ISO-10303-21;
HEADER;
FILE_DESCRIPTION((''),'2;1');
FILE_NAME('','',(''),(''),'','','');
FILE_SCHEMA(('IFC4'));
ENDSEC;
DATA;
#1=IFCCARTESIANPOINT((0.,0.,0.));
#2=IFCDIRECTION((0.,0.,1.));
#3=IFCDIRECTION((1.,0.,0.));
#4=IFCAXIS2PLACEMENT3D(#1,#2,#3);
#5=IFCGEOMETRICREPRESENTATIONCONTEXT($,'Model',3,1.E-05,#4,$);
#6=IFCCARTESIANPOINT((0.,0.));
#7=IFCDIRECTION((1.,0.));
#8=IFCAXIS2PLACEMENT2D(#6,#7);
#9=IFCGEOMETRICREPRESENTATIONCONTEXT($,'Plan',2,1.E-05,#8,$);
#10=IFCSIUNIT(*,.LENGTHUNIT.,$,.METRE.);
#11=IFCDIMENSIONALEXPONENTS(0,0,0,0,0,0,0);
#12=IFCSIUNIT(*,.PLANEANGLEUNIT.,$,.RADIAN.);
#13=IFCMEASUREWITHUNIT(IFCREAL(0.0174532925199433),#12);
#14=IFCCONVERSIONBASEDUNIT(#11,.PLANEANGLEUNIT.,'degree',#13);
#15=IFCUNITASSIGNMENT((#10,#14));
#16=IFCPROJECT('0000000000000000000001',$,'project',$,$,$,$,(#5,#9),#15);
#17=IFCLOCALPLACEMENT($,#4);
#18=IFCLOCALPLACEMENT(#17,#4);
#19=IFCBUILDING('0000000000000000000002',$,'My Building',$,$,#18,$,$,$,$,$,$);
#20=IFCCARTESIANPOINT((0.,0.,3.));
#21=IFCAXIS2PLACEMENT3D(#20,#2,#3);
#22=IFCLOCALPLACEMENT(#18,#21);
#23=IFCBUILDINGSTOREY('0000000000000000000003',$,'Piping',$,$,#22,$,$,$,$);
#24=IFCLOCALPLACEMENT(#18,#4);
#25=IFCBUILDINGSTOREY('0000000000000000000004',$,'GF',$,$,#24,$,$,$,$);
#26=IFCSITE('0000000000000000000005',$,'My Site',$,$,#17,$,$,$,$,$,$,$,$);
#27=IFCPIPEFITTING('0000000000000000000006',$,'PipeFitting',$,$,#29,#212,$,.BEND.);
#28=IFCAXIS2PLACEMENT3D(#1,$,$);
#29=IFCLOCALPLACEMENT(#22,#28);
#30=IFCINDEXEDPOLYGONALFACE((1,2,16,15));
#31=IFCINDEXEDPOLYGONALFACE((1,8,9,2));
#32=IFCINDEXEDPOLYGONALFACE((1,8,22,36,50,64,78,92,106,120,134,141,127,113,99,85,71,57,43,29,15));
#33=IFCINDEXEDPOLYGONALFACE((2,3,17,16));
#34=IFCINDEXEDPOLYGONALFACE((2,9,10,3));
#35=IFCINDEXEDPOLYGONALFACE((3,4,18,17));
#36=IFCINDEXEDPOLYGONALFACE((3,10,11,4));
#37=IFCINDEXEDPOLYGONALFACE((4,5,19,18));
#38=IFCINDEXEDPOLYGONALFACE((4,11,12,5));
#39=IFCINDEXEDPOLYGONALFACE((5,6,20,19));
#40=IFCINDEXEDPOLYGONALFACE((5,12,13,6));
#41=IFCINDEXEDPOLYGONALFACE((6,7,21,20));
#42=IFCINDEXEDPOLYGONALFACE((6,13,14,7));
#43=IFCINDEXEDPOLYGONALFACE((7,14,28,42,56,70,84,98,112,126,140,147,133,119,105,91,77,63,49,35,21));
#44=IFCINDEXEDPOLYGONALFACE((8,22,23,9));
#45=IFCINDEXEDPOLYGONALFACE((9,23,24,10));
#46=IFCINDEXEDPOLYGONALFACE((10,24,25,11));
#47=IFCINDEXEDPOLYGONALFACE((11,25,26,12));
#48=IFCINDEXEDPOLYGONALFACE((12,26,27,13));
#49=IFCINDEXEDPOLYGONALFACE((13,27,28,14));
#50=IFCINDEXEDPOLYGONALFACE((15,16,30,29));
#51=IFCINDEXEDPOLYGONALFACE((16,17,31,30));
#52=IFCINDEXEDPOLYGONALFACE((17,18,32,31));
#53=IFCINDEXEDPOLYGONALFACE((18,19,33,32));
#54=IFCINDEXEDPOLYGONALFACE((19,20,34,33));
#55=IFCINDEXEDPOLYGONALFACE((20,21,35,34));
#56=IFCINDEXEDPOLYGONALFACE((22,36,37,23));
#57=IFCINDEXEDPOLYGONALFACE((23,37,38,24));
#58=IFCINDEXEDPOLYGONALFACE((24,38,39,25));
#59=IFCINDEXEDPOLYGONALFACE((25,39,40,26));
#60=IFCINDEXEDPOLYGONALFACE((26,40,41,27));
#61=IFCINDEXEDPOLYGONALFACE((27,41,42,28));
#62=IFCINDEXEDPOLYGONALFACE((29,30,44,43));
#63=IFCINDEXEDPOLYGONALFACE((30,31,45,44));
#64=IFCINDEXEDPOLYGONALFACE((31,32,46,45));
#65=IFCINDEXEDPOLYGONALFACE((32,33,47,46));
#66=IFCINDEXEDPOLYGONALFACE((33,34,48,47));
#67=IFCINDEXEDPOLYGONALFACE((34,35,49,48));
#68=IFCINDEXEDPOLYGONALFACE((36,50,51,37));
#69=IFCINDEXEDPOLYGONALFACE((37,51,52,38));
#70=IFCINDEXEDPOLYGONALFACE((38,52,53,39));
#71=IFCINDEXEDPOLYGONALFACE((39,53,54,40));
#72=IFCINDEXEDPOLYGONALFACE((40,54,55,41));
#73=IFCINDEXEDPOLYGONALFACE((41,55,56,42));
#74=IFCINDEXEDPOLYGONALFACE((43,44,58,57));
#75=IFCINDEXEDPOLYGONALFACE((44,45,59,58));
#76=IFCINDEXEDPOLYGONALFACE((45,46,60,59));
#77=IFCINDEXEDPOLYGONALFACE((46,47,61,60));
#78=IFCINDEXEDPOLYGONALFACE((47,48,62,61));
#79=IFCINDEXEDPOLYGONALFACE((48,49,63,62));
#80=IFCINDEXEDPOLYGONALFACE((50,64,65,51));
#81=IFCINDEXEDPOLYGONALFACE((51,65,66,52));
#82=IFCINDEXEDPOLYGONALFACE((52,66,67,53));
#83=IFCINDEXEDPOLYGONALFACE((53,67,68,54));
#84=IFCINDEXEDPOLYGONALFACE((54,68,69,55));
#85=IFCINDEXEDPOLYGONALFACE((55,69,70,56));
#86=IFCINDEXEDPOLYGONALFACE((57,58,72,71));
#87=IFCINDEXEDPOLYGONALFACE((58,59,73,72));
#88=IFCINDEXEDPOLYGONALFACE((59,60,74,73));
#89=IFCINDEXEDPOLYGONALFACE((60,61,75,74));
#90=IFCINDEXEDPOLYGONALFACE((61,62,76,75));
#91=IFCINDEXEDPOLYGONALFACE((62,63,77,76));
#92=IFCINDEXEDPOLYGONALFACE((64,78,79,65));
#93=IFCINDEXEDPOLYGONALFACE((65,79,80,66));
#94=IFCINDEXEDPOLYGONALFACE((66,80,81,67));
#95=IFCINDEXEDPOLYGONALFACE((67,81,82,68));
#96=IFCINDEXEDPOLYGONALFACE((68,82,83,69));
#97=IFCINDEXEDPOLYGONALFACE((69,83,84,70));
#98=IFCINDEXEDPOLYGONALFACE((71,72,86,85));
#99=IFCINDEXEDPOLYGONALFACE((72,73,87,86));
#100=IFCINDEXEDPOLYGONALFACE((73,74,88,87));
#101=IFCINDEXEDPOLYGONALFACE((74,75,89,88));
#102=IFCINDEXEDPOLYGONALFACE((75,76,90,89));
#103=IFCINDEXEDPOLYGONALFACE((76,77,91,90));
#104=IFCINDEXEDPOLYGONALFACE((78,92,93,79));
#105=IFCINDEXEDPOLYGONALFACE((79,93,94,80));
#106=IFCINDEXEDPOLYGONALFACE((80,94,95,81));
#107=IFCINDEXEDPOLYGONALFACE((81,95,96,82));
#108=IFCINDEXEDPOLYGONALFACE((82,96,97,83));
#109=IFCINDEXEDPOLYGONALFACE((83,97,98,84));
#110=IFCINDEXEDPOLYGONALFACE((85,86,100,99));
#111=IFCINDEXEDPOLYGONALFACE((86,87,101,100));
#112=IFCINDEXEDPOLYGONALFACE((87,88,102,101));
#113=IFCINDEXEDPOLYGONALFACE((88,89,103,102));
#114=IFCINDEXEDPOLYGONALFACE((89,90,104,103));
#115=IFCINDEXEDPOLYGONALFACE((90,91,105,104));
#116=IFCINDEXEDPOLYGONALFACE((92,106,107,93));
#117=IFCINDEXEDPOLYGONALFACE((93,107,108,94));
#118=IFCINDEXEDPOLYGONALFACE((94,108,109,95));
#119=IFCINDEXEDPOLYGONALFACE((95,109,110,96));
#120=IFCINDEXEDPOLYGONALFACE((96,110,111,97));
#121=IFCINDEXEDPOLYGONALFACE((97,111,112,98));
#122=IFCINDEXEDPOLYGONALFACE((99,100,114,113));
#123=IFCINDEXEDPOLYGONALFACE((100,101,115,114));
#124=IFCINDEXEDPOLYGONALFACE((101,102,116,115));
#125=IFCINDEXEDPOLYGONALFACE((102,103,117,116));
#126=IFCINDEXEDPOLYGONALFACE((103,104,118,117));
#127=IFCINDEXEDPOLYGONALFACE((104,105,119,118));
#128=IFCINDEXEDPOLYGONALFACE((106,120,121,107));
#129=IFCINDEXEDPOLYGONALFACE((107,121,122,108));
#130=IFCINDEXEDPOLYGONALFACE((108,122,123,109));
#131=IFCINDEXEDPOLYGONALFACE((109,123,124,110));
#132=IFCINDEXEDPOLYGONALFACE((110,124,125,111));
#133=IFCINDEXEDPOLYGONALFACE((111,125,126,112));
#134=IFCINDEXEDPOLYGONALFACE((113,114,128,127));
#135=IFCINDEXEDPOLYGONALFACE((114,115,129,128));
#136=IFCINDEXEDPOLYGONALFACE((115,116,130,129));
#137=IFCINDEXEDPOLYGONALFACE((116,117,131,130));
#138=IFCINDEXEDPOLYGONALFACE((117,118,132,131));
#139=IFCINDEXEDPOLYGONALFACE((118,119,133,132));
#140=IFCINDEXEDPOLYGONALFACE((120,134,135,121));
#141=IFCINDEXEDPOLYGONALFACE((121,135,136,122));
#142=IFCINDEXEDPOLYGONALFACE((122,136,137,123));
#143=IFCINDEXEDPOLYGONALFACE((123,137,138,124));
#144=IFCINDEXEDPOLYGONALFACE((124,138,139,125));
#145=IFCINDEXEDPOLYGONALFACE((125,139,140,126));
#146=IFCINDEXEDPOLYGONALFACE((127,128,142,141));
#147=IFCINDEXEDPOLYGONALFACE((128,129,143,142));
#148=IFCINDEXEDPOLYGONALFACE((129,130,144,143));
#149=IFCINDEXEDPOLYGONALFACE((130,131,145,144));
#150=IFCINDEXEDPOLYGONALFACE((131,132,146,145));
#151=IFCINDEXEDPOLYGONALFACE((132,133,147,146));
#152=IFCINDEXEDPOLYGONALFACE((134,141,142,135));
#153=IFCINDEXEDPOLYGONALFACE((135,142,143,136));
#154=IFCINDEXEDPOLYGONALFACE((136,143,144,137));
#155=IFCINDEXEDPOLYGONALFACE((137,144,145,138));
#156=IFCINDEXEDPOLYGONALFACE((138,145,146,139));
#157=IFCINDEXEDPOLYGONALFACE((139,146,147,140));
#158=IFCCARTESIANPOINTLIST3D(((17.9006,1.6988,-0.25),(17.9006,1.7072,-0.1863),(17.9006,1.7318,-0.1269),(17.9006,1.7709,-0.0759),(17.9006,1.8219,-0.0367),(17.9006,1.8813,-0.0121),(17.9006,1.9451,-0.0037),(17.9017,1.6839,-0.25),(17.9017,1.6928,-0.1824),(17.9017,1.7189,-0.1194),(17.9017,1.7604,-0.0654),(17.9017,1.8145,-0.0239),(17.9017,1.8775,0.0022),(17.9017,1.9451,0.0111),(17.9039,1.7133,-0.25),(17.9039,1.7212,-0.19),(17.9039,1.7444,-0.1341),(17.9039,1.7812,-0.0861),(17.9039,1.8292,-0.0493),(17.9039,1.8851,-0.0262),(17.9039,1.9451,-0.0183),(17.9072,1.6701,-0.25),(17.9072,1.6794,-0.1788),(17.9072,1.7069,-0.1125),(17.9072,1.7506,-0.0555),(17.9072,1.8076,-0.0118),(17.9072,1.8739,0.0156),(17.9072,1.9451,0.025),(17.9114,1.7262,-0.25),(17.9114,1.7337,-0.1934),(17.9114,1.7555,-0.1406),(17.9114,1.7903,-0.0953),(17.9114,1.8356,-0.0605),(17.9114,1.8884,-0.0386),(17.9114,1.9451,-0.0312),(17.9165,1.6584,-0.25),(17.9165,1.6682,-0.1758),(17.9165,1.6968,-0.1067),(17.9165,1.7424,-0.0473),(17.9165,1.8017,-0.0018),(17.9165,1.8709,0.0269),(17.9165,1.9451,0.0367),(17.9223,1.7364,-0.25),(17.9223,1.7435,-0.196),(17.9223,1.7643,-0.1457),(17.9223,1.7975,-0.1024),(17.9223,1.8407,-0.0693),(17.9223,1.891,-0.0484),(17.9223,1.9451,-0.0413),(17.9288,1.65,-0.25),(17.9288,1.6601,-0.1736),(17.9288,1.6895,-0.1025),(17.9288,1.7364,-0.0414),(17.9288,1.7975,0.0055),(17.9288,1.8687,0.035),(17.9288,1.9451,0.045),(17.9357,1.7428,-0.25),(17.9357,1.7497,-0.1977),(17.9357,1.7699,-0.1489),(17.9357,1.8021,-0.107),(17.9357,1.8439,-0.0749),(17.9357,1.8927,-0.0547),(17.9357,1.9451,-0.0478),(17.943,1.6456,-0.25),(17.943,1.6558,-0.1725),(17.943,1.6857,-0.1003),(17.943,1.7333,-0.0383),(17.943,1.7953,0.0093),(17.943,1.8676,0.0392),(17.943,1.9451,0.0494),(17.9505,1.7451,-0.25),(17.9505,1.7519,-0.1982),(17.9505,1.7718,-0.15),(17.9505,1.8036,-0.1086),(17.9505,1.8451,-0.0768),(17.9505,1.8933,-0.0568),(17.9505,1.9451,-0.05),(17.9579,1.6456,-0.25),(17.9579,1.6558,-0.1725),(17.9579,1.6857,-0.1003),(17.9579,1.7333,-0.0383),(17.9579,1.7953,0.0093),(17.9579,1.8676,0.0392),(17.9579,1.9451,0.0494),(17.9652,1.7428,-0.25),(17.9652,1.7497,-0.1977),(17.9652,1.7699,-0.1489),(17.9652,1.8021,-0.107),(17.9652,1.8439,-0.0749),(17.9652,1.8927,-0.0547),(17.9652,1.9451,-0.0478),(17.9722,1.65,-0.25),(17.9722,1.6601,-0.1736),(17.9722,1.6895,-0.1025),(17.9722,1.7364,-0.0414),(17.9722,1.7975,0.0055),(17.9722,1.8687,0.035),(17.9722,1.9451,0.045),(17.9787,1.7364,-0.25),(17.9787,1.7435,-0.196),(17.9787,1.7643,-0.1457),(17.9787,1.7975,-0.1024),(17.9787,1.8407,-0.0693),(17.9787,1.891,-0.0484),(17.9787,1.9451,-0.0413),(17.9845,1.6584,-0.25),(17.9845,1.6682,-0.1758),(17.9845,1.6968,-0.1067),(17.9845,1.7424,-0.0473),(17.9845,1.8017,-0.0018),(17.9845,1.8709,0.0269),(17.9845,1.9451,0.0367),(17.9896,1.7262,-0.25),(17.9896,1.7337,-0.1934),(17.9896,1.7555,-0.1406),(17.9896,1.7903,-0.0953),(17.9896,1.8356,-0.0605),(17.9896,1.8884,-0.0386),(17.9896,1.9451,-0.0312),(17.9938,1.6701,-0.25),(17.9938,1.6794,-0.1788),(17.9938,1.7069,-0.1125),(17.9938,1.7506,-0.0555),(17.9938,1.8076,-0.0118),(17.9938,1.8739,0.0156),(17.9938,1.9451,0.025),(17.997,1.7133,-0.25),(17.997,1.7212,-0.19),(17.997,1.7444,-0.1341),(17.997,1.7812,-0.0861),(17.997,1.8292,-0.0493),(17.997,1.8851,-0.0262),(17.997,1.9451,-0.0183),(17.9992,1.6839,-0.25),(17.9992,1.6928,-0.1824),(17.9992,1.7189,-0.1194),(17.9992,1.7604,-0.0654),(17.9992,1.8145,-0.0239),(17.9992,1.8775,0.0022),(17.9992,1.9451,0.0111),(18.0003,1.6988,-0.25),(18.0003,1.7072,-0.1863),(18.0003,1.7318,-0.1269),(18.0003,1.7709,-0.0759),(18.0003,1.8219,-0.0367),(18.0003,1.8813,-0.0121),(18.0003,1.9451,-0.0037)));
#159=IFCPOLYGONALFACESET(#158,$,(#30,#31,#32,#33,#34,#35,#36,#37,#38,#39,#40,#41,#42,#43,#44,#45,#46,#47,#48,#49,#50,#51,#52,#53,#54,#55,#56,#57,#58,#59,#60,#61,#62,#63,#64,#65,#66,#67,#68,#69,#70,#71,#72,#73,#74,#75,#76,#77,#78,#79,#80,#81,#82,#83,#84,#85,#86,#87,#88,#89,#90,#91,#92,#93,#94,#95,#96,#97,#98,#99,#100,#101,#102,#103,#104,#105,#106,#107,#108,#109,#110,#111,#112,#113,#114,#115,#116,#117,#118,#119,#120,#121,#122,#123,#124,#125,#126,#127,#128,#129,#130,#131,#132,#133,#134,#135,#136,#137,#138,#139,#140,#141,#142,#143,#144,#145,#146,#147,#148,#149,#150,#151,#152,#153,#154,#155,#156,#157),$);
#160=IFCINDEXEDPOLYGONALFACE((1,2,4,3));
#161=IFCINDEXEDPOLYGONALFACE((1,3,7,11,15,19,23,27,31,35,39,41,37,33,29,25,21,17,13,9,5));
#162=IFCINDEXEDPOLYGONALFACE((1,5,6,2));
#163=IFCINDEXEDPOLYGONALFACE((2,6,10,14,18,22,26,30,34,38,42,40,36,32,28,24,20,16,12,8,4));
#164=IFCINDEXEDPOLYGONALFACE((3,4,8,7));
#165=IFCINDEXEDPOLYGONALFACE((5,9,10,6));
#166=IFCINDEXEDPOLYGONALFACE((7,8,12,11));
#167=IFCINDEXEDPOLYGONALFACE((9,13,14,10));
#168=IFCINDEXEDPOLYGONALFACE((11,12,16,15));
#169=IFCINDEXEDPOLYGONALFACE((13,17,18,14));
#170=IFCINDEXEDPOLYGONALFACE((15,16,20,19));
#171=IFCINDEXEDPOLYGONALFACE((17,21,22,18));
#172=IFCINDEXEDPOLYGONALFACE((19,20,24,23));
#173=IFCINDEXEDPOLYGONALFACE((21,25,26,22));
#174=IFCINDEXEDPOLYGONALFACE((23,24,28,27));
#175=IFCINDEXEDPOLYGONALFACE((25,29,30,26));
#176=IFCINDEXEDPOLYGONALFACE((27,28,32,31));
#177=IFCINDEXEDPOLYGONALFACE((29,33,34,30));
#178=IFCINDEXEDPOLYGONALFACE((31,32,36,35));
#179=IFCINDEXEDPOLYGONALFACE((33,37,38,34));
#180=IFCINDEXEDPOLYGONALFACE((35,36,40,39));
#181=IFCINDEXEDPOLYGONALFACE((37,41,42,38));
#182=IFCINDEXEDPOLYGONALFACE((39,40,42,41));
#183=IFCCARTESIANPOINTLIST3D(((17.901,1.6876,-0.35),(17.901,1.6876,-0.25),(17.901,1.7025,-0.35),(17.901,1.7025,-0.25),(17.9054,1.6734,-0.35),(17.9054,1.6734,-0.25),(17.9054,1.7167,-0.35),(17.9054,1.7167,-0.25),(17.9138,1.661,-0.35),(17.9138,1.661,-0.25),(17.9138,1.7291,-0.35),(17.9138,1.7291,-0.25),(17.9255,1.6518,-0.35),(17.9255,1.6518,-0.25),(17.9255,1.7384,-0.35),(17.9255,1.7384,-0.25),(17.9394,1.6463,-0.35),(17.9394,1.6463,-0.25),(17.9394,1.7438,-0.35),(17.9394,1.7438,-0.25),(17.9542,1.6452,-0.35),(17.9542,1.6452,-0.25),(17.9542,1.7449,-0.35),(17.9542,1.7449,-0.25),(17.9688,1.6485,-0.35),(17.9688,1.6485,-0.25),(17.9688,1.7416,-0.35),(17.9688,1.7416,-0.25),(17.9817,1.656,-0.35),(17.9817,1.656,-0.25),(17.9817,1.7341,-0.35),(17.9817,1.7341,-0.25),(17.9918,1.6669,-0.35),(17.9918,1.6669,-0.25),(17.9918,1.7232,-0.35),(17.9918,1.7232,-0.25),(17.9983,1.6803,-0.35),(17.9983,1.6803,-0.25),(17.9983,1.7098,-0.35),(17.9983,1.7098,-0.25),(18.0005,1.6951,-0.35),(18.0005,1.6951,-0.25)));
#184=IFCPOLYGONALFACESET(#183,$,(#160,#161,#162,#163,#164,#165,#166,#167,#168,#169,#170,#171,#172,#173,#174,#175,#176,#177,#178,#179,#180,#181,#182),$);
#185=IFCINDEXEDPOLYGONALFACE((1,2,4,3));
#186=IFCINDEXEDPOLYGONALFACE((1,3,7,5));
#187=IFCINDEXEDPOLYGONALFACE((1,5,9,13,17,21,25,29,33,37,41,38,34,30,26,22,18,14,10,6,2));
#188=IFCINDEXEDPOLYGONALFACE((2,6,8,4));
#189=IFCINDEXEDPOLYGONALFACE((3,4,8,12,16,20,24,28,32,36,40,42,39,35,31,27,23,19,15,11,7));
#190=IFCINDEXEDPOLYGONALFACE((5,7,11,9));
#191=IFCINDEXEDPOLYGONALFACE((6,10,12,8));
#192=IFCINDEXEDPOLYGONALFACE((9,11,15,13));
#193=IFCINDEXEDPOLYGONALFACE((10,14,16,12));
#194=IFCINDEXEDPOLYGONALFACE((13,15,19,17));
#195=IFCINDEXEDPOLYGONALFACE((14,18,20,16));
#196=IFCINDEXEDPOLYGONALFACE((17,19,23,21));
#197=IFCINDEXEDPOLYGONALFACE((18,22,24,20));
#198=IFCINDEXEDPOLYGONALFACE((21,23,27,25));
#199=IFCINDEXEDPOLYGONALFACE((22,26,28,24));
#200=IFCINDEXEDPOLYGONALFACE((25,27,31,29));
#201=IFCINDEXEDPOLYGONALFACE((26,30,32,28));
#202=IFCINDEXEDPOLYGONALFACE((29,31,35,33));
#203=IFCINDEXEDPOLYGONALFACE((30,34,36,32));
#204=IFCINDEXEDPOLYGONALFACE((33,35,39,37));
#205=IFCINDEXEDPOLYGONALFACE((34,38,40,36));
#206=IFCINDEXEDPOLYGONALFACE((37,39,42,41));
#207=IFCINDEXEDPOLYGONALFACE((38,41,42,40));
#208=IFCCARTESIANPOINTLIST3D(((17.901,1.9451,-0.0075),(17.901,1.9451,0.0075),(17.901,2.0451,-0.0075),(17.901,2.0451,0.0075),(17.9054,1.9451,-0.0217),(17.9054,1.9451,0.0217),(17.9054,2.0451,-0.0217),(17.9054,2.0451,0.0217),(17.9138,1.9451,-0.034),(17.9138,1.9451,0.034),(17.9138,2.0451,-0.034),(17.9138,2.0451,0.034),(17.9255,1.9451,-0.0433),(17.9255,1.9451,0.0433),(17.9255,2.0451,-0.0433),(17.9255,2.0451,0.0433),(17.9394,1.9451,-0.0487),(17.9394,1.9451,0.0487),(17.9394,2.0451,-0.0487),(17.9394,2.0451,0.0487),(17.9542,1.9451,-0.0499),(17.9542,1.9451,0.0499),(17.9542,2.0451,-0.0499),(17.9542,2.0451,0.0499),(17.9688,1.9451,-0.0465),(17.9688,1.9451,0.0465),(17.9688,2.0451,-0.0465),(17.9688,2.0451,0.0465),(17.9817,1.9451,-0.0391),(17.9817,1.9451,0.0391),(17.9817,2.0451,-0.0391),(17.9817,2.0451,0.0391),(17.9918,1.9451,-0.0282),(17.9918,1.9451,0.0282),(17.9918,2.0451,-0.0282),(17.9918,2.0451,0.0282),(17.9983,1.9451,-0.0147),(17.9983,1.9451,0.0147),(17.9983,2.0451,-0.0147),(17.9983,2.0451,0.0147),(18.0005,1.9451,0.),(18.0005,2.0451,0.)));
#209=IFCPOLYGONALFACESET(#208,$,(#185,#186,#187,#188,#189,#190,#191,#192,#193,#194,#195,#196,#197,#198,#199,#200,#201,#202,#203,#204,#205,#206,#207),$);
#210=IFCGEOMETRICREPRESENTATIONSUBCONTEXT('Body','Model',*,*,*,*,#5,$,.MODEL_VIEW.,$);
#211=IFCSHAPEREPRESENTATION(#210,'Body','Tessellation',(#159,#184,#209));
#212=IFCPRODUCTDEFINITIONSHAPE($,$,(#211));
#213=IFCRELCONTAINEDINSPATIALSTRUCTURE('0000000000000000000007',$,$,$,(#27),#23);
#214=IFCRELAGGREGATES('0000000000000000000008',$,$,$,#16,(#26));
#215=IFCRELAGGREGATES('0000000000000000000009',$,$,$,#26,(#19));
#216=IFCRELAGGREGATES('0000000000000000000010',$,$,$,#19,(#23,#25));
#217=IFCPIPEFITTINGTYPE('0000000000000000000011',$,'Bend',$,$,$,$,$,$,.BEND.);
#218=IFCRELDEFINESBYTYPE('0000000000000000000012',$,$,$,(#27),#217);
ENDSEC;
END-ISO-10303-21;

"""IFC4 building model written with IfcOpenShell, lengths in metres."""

from ifc_helpers import new_model, entity, si_unit, converted_unit, frame, origin_with_axes, origin_2d_with_axis, place, context, subcontext, project, spatial, circle, extrude, source, transform, mapped, type_object, type_shapes, element, save


model = new_model("IFC4")

# Units and contexts
model_context = context("Model", 3, precision=1e-05, world=origin_with_axes())
plan_context = context("Plan", 2, precision=1e-05, world=origin_2d_with_axis())
body_context_1 = subcontext(model_context, "Body", "Model", "MODEL_VIEW")
ifc_project = project(units=[si_unit("LENGTHUNIT", "METRE"), converted_unit("PLANEANGLEUNIT", "degree", entity("IfcReal", 0.0174532925199433), si_unit("PLANEANGLEUNIT", "RADIAN"), dimensions=[0, 0, 0, 0, 0, 0, 0])], contexts=[model_context, plan_context])

# Site, building, storey
site_placement = place(None, origin_with_axes())
site = spatial("IfcSite", under=ifc_project, at=site_placement, Name="My Site")
building_placement = place(site_placement, origin_with_axes())
building = spatial("IfcBuilding", under=site, at=building_placement, Name="My Building")
storey_1_placement = place(building_placement, frame((0.0, 0.0, 3.0), z_axis=(0.0, 0.0, 1.0), x_axis=(1.0, 0.0, 0.0)))
storey_1 = spatial("IfcBuildingStorey", under=building, at=storey_1_placement, Name="Piping")

# Shared definitions
storey_2_placement = place(building_placement, origin_with_axes())
storey_2 = spatial("IfcBuildingStorey", under=building, at=storey_2_placement, Name="GF")

# Pipe fitting
pipe_fitting_type_1 = type_object("IfcPipeFittingType", Name="Bend", PredefinedType="BEND")
shared_shape_1 = source(origin_with_axes(), body_context_1, "Body", "SolidModel", [
    entity("IfcSweptDiskSolid", entity("IfcIndexedPolyCurve", entity("IfcCartesianPointList3D", [[0.0, 0.0, -0.1], [0.0, -0.0732, -0.2768], [0.0, -0.25, -0.35]]), [entity("IfcArcIndex", [1, 2, 3])]), 0.05),
    extrude(circle(Radius=0.05), origin_with_axes(), (0.0, 0.0, -1.0), 0.1),
    extrude(circle(Radius=0.05), frame((0.0, -0.25, -0.35), z_axis=(0.0, -1.0, 0.0), x_axis=(1.0, 0.0, 0.0)), (0.0, 0.0, 1.0), 0.1),
])
type_shapes(pipe_fitting_type_1, [shared_shape_1])
for number, where, z_axis, x_axis, name in (
    (1, (17.9505, 1.6951, -0.35), (0.0, 0.0, -1.0), (1.0, 0.0, 0.0), "PipeFitting"),
):
    element("IfcPipeFitting", number, at=place(storey_1_placement, frame(where, z_axis=z_axis, x_axis=x_axis)), inside=storey_1, type_object=pipe_fitting_type_1, Name=name, PredefinedType="BEND", context=body_context_1, shape_type="MappedRepresentation", body=[
        mapped(shared_shape_1, transform((0.0, 0.0, 0.0), x_axis=(1.0, 0.0, 0.0), y_axis=(0.0, 1.0, 0.0), z_axis=(0.0, 0.0, 1.0), scale=1.0)),
    ])

save(model, "model.ifc")
